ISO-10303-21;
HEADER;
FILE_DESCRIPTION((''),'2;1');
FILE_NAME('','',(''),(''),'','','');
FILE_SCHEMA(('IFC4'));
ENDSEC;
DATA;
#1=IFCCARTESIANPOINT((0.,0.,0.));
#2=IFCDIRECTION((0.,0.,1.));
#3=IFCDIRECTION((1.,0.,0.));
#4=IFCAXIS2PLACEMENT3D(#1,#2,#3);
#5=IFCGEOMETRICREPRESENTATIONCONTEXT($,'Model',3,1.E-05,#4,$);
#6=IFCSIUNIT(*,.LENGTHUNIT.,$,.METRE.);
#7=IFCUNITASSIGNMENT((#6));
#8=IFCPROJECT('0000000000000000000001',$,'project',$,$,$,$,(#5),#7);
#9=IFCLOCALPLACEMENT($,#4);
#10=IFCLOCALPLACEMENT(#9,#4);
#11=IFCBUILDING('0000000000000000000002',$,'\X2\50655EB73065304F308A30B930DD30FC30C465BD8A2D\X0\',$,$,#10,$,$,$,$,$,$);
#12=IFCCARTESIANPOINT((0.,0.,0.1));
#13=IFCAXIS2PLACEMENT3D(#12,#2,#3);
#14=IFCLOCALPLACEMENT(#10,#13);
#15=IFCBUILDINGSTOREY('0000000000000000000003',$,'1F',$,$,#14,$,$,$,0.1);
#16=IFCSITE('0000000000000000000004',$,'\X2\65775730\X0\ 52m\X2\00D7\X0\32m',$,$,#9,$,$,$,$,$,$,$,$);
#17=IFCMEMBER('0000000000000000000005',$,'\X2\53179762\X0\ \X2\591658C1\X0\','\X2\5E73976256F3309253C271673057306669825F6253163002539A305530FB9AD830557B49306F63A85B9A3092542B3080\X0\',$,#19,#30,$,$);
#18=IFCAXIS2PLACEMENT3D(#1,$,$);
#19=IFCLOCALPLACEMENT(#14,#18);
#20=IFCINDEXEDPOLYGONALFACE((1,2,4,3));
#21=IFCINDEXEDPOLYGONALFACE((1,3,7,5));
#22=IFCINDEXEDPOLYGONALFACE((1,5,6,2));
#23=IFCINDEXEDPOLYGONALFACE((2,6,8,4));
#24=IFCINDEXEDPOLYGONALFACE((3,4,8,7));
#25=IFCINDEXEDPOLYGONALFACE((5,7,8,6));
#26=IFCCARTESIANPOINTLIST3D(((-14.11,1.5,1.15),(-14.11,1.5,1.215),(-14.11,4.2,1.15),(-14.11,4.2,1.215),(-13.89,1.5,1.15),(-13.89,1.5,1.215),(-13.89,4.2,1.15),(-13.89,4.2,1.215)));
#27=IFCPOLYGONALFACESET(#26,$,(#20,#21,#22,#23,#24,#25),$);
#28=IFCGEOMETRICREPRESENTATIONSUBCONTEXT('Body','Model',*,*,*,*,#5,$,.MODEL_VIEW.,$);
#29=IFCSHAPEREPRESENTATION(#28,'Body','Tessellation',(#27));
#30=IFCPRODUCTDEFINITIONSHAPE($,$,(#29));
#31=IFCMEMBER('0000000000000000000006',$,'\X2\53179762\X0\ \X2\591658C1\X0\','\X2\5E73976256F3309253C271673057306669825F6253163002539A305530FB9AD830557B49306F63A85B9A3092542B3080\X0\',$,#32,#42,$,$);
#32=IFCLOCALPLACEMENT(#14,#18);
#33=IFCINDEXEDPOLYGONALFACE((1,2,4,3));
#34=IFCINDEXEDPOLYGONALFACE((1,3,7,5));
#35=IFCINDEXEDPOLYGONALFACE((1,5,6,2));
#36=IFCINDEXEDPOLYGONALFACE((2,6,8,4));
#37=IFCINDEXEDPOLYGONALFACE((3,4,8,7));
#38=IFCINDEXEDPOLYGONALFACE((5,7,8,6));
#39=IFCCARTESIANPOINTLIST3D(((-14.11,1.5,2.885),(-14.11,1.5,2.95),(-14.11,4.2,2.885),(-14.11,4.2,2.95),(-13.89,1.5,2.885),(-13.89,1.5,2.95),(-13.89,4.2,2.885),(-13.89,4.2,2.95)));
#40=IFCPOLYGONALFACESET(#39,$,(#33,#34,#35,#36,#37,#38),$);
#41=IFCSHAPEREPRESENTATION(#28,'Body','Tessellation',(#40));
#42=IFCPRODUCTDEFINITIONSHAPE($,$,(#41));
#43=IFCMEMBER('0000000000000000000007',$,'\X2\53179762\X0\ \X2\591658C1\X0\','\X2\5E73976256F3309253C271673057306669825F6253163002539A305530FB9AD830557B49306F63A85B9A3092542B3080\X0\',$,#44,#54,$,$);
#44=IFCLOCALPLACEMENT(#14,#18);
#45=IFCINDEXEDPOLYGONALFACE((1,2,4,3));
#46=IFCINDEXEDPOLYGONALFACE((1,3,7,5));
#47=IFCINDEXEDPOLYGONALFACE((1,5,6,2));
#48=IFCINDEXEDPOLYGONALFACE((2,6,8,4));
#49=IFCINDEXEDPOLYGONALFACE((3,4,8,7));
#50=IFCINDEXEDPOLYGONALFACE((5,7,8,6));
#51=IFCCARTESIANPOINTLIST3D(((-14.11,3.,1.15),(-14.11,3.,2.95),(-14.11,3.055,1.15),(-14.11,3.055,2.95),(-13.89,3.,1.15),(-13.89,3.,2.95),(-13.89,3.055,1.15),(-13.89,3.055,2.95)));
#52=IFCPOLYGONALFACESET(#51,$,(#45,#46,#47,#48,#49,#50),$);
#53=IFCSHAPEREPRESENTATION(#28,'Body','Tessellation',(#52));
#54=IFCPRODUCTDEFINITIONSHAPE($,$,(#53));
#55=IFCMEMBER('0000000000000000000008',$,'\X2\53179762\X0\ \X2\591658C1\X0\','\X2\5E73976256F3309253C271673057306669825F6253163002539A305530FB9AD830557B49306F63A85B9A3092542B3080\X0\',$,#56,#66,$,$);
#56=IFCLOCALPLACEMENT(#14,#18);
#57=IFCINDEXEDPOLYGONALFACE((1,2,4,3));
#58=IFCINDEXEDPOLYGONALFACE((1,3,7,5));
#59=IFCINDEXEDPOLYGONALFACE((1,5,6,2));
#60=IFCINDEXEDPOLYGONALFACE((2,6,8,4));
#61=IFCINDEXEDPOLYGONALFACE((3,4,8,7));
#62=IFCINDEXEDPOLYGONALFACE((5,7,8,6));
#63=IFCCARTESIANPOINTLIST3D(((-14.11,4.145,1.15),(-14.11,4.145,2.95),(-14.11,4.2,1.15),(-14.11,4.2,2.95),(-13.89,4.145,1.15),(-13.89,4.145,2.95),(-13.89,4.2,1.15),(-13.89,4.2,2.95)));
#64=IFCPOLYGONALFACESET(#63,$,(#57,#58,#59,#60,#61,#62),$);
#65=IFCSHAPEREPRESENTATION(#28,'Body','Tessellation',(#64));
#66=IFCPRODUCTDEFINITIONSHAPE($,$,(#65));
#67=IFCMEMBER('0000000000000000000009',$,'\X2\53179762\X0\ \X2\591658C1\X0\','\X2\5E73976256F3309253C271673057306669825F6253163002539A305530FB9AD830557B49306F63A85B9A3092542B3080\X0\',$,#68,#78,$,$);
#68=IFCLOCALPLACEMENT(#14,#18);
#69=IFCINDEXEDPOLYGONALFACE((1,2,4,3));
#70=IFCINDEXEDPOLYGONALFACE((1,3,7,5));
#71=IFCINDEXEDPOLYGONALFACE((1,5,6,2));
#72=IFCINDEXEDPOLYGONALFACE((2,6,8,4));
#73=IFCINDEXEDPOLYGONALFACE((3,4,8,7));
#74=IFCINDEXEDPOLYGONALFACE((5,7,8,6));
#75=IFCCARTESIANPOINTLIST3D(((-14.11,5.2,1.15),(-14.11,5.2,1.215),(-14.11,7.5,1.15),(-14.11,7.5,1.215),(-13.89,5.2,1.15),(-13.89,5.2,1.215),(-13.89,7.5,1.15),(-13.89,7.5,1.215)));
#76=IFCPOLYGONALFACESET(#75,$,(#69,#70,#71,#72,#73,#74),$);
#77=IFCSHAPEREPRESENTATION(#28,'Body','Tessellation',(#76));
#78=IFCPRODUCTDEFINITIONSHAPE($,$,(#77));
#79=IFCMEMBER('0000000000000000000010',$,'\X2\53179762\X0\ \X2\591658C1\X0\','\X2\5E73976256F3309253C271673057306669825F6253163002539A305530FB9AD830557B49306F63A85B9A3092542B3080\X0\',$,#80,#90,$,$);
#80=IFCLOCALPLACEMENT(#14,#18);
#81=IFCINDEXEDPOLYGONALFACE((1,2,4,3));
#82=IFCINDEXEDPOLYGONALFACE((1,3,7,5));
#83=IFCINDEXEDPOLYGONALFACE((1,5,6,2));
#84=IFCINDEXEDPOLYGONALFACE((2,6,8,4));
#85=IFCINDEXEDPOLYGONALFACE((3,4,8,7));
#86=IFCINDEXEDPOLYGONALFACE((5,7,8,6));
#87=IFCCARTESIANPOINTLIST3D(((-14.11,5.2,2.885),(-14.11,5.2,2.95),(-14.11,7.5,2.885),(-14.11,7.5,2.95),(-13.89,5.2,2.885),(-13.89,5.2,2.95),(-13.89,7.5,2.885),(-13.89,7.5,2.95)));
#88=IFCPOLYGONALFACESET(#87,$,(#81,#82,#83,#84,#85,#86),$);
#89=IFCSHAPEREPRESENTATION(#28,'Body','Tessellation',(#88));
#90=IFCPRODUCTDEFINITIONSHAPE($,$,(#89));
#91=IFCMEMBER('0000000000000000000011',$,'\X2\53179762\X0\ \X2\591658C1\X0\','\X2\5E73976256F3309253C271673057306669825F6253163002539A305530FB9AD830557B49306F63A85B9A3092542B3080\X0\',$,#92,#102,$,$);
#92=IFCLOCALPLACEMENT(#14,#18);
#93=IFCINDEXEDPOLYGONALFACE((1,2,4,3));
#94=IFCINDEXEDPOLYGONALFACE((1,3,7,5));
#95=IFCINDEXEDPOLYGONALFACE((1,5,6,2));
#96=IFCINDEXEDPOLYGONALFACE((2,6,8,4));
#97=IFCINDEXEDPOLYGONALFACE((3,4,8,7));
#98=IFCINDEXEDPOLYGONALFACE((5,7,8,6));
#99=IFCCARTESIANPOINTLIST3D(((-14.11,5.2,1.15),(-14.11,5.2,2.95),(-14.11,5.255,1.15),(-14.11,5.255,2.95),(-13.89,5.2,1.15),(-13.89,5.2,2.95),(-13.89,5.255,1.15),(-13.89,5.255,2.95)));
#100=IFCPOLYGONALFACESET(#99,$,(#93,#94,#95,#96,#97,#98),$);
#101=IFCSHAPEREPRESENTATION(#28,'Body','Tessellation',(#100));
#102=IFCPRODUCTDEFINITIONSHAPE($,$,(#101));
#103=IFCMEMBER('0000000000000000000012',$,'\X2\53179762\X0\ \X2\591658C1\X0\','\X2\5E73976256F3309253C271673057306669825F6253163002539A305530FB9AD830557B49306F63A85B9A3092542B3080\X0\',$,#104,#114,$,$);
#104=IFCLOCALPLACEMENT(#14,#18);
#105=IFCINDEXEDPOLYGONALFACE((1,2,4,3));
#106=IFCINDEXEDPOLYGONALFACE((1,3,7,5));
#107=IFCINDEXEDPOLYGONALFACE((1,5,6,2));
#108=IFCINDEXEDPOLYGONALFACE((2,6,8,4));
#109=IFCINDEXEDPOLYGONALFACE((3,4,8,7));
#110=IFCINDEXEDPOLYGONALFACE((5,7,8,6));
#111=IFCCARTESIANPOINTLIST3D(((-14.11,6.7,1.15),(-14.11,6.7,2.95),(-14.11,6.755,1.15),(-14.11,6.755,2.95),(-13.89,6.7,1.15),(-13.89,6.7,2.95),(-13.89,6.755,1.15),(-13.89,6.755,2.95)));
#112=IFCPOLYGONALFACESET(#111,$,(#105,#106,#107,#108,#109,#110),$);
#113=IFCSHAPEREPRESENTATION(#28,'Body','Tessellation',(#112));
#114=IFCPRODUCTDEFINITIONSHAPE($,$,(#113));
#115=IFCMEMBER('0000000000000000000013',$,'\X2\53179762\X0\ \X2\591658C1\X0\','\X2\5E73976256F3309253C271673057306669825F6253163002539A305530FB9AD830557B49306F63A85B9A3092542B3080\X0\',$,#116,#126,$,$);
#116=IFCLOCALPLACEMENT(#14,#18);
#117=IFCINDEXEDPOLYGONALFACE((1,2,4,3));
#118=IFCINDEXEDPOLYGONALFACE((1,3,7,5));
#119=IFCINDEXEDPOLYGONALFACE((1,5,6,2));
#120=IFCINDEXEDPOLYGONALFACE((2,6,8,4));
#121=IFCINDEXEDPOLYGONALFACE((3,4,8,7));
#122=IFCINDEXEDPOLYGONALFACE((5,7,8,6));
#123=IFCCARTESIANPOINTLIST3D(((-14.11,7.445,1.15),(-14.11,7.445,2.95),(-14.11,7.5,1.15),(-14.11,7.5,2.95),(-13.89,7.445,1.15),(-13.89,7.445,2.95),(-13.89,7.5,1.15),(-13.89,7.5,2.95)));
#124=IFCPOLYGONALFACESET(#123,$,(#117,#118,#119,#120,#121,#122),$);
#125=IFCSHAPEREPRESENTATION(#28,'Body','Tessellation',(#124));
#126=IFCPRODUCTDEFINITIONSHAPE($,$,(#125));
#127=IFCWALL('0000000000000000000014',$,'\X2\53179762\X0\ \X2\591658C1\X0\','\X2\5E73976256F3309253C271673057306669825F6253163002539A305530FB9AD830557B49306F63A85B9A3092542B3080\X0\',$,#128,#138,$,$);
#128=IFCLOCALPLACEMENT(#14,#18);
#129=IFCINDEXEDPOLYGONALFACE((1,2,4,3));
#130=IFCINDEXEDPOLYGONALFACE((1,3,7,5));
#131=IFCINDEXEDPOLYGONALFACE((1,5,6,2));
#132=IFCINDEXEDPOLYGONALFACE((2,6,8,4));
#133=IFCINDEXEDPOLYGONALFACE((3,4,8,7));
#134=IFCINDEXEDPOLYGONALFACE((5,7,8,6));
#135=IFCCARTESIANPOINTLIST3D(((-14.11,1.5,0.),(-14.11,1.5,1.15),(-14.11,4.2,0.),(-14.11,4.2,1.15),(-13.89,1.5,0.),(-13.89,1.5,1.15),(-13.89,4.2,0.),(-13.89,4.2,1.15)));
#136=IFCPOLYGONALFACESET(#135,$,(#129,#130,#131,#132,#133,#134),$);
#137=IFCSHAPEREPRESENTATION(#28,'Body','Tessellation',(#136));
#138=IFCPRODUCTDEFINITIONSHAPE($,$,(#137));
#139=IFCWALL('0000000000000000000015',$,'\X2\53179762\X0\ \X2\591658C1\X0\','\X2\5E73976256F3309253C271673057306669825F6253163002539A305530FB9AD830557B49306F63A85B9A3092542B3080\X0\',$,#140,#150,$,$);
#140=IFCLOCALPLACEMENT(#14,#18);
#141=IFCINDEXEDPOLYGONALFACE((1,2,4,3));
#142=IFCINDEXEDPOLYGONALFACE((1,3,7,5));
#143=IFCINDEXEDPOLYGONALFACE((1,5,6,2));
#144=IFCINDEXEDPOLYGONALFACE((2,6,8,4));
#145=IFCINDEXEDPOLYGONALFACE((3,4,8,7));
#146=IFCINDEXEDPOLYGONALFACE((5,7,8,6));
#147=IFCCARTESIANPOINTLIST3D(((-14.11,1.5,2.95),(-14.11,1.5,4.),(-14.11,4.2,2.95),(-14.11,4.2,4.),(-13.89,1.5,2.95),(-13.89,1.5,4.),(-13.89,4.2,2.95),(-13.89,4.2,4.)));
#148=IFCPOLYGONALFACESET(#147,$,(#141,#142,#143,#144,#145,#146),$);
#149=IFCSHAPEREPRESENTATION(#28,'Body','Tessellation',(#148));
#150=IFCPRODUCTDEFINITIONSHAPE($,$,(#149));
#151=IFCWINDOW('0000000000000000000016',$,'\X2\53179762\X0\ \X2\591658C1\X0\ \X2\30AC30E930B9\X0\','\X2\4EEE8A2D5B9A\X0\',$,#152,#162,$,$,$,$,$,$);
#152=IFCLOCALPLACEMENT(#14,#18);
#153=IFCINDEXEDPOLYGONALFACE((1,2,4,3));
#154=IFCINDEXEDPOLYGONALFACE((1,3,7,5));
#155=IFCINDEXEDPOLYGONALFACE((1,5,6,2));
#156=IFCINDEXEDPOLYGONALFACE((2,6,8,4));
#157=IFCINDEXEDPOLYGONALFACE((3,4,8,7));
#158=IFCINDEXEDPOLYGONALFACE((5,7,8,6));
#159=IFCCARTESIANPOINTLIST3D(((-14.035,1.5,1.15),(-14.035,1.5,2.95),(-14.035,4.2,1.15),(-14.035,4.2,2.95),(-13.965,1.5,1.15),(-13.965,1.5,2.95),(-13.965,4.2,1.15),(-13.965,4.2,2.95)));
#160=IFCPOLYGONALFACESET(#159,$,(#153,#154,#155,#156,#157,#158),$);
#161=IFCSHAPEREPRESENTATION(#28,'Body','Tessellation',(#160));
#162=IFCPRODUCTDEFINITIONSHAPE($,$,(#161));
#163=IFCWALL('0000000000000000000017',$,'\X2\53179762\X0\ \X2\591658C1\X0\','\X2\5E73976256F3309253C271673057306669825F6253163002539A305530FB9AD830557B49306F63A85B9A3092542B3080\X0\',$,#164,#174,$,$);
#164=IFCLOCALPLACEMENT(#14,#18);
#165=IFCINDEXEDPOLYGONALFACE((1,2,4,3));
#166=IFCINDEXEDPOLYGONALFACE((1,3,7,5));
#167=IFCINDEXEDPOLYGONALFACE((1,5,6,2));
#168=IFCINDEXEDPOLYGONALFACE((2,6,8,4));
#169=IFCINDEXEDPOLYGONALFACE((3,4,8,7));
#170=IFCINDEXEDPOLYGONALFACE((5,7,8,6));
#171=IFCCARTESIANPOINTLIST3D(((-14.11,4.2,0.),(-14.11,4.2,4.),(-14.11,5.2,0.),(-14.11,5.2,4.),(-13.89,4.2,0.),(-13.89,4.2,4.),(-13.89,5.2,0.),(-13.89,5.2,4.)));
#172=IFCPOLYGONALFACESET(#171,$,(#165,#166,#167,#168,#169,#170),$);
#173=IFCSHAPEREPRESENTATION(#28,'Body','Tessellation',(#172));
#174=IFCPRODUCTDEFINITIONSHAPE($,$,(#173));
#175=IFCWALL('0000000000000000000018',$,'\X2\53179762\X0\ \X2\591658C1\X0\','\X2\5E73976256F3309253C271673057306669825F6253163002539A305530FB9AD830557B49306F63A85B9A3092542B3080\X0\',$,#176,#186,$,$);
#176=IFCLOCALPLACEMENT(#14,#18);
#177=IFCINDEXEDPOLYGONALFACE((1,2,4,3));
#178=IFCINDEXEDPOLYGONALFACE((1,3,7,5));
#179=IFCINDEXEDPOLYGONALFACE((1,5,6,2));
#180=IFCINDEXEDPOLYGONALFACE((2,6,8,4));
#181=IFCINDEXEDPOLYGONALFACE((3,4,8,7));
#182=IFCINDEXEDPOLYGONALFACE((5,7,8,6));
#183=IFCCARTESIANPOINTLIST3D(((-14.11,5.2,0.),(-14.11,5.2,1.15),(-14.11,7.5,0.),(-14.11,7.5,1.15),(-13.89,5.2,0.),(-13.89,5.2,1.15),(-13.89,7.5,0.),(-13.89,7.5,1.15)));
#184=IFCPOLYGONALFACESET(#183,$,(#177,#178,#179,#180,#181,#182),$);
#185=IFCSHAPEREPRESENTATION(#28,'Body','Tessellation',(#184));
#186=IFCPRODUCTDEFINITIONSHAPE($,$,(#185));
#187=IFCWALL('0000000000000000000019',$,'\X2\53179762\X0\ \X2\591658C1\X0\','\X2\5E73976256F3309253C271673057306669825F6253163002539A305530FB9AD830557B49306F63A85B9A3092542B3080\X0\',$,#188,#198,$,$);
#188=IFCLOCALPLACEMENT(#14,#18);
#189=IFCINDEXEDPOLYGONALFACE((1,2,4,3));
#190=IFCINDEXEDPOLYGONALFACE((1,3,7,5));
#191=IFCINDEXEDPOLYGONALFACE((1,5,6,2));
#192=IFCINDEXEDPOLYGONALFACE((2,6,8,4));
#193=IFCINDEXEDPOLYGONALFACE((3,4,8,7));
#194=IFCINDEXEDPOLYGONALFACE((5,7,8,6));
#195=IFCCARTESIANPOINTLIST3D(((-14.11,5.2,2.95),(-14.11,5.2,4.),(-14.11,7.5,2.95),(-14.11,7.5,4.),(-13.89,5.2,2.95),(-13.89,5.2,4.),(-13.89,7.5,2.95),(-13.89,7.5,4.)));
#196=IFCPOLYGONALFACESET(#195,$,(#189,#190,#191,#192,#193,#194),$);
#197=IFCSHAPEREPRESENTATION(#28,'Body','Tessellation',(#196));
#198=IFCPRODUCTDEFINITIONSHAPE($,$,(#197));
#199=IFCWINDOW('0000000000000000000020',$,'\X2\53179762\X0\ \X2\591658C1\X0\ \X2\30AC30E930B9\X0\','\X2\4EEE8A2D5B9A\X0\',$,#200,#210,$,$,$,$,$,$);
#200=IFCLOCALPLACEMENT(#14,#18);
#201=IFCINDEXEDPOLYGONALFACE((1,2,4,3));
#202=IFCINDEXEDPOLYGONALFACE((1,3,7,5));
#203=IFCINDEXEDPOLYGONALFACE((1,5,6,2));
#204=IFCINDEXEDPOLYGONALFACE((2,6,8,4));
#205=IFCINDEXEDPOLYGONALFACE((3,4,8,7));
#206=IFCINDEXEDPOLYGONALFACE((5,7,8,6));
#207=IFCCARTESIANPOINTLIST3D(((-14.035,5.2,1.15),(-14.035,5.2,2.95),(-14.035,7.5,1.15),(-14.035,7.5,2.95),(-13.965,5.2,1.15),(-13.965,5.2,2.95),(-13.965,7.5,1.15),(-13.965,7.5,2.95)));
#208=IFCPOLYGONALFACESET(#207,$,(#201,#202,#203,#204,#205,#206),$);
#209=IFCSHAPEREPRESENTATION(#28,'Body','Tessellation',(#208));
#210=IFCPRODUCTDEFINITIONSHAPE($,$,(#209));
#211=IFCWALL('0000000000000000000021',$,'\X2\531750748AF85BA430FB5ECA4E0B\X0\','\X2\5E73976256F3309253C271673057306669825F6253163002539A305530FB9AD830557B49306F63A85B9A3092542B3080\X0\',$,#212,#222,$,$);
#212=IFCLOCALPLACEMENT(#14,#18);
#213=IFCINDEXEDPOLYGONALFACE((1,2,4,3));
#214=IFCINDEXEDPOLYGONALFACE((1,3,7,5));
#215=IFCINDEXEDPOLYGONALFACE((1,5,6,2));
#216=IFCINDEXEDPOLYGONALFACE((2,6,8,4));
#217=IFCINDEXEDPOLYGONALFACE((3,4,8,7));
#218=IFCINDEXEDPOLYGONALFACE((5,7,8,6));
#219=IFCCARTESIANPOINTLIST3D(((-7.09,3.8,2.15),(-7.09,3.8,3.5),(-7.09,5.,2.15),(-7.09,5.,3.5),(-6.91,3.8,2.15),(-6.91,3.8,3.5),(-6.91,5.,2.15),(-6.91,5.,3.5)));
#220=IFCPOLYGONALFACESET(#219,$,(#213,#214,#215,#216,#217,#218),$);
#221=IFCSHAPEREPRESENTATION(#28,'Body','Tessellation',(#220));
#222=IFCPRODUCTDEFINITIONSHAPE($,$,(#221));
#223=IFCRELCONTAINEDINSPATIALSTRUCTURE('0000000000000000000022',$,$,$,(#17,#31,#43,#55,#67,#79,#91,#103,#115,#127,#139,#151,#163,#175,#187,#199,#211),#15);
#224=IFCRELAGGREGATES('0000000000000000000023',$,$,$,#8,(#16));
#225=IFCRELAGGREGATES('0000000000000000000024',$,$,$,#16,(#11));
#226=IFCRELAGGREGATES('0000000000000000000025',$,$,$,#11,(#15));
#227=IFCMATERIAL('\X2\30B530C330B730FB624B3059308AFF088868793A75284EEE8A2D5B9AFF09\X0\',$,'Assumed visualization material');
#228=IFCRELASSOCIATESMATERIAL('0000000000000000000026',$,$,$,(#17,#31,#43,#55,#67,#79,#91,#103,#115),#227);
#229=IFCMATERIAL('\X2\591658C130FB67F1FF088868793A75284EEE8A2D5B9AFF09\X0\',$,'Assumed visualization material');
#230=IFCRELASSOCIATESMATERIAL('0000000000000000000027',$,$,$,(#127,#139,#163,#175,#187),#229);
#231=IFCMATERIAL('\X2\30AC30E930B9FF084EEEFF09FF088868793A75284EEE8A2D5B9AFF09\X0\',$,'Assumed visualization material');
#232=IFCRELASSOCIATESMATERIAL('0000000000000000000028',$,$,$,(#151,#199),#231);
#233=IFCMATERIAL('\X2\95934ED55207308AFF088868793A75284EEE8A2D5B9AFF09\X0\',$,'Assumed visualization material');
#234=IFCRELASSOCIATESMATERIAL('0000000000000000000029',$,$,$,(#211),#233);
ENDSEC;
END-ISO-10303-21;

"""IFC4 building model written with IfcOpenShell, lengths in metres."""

from ifc_helpers import new_model, si_unit, frame, origin_with_axes, place, context, subcontext, project, spatial, rectangle, extrude, material, element, save


model = new_model("IFC4")

# Units and contexts
model_context = context("Model", 3, precision=1e-05, world=origin_with_axes())
body_context = subcontext(model_context, "Body", "Model", "MODEL_VIEW")
ifc_project = project(units=[si_unit("LENGTHUNIT", "METRE")], contexts=[model_context])

# Site, building, storey
site_placement = place(None, origin_with_axes())
site = spatial("IfcSite", under=ifc_project, at=site_placement, Name="敷地 52m×32m")
building_placement = place(site_placement, origin_with_axes())
building = spatial("IfcBuilding", under=site, at=building_placement, Name="健康づくりスポーツ施設")
storey_placement = place(building_placement, frame((0.0, 0.0, 0.1), z_axis=(0.0, 0.0, 1.0), x_axis=(1.0, 0.0, 0.0)))
storey = spatial("IfcBuildingStorey", under=building, at=storey_placement, Name="1F", Elevation=0.1)

# Members
ifc_material_1 = material(Name="サッシ・手すり（表示用仮設定）", Category="Assumed visualization material")
for number, where, z_axis, x_axis, name in (
    (1, (-14.0, 2.85, 1.15), (0.0, 0.0, 1.0), (1.0, 0.0, 0.0), "北面 外壁"),
    (2, (-14.0, 2.85, 2.885), (0.0, 0.0, 1.0), (1.0, 0.0, 0.0), "北面 外壁"),
):
    element("IfcMember", number, at=place(storey_placement, frame(where, z_axis=z_axis, x_axis=x_axis)), inside=storey, material=ifc_material_1, Name=name, Description="平面図を参照して概形化。厚さ・高さ等は推定を含む", context=body_context, shape_type="SweptSolid", body=[
        extrude(rectangle(XDim=0.22, YDim=2.7), origin_with_axes(), (0.0, 0.0, 1.0), 0.065),
    ])
for number, where, z_axis, x_axis, name in (
    (3, (-14.0, 3.0275, 1.15), (0.0, 0.0, 1.0), (1.0, 0.0, 0.0), "北面 外壁"),
    (4, (-14.0, 4.1725, 1.15), (0.0, 0.0, 1.0), (1.0, 0.0, 0.0), "北面 外壁"),
):
    element("IfcMember", number, at=place(storey_placement, frame(where, z_axis=z_axis, x_axis=x_axis)), inside=storey, material=ifc_material_1, Name=name, Description="平面図を参照して概形化。厚さ・高さ等は推定を含む", context=body_context, shape_type="SweptSolid", body=[
        extrude(rectangle(XDim=0.22, YDim=0.055), origin_with_axes(), (0.0, 0.0, 1.0), 1.8),
    ])
for number, where, z_axis, x_axis, name in (
    (5, (-14.0, 6.35, 1.15), (0.0, 0.0, 1.0), (1.0, 0.0, 0.0), "北面 外壁"),
    (6, (-14.0, 6.35, 2.885), (0.0, 0.0, 1.0), (1.0, 0.0, 0.0), "北面 外壁"),
):
    element("IfcMember", number, at=place(storey_placement, frame(where, z_axis=z_axis, x_axis=x_axis)), inside=storey, material=ifc_material_1, Name=name, Description="平面図を参照して概形化。厚さ・高さ等は推定を含む", context=body_context, shape_type="SweptSolid", body=[
        extrude(rectangle(XDim=0.22, YDim=2.3), origin_with_axes(), (0.0, 0.0, 1.0), 0.065),
    ])
for number, where, z_axis, x_axis, name in (
    (7, (-14.0, 5.2275, 1.15), (0.0, 0.0, 1.0), (1.0, 0.0, 0.0), "北面 外壁"),
    (8, (-14.0, 6.7275, 1.15), (0.0, 0.0, 1.0), (1.0, 0.0, 0.0), "北面 外壁"),
    (9, (-14.0, 7.4725, 1.15), (0.0, 0.0, 1.0), (1.0, 0.0, 0.0), "北面 外壁"),
):
    element("IfcMember", number, at=place(storey_placement, frame(where, z_axis=z_axis, x_axis=x_axis)), inside=storey, material=ifc_material_1, Name=name, Description="平面図を参照して概形化。厚さ・高さ等は推定を含む", context=body_context, shape_type="SweptSolid", body=[
        extrude(rectangle(XDim=0.22, YDim=0.055), origin_with_axes(), (0.0, 0.0, 1.0), 1.8),
    ])

# Walls
ifc_material_2 = material(Name="外壁・柱（表示用仮設定）", Category="Assumed visualization material")
wall_1_placement = place(storey_placement, frame((-14.0, 2.85, 0.0), z_axis=(0.0, 0.0, 1.0), x_axis=(1.0, 0.0, 0.0)))
element("IfcWall", 10, at=wall_1_placement, inside=storey, material=ifc_material_2, Name="北面 外壁", Description="平面図を参照して概形化。厚さ・高さ等は推定を含む", context=body_context, shape_type="SweptSolid", body=[
    extrude(rectangle(XDim=0.22, YDim=2.7), origin_with_axes(), (0.0, 0.0, 1.0), 1.15),
])
wall_2_placement = place(storey_placement, frame((-14.0, 2.85, 2.95), z_axis=(0.0, 0.0, 1.0), x_axis=(1.0, 0.0, 0.0)))
element("IfcWall", 11, at=wall_2_placement, inside=storey, material=ifc_material_2, Name="北面 外壁", Description="平面図を参照して概形化。厚さ・高さ等は推定を含む", context=body_context, shape_type="SweptSolid", body=[
    extrude(rectangle(XDim=0.22, YDim=2.7), origin_with_axes(), (0.0, 0.0, 1.0), 1.05),
])

# Window
ifc_material_3 = material(Name="ガラス（仮）（表示用仮設定）", Category="Assumed visualization material")
window_1_placement = place(storey_placement, frame((-14.0, 2.85, 1.15), z_axis=(0.0, 0.0, 1.0), x_axis=(1.0, 0.0, 0.0)))
element("IfcWindow", 12, at=window_1_placement, inside=storey, material=ifc_material_3, Name="北面 外壁 ガラス", Description="仮設定", context=body_context, shape_type="SweptSolid", body=[
    extrude(rectangle(XDim=0.07, YDim=2.7), origin_with_axes(), (0.0, 0.0, 1.0), 1.8),
])

# Walls
wall_3_placement = place(storey_placement, frame((-14.0, 4.7, 0.0), z_axis=(0.0, 0.0, 1.0), x_axis=(1.0, 0.0, 0.0)))
element("IfcWall", 13, at=wall_3_placement, inside=storey, material=ifc_material_2, Name="北面 外壁", Description="平面図を参照して概形化。厚さ・高さ等は推定を含む", context=body_context, shape_type="SweptSolid", body=[
    extrude(rectangle(XDim=0.22, YDim=1.0), origin_with_axes(), (0.0, 0.0, 1.0), 4.0),
])
wall_4_placement = place(storey_placement, frame((-14.0, 6.35, 0.0), z_axis=(0.0, 0.0, 1.0), x_axis=(1.0, 0.0, 0.0)))
element("IfcWall", 14, at=wall_4_placement, inside=storey, material=ifc_material_2, Name="北面 外壁", Description="平面図を参照して概形化。厚さ・高さ等は推定を含む", context=body_context, shape_type="SweptSolid", body=[
    extrude(rectangle(XDim=0.22, YDim=2.3), origin_with_axes(), (0.0, 0.0, 1.0), 1.15),
])
wall_5_placement = place(storey_placement, frame((-14.0, 6.35, 2.95), z_axis=(0.0, 0.0, 1.0), x_axis=(1.0, 0.0, 0.0)))
element("IfcWall", 15, at=wall_5_placement, inside=storey, material=ifc_material_2, Name="北面 外壁", Description="平面図を参照して概形化。厚さ・高さ等は推定を含む", context=body_context, shape_type="SweptSolid", body=[
    extrude(rectangle(XDim=0.22, YDim=2.3), origin_with_axes(), (0.0, 0.0, 1.0), 1.05),
])

# Window
window_2_placement = place(storey_placement, frame((-14.0, 6.35, 1.15), z_axis=(0.0, 0.0, 1.0), x_axis=(1.0, 0.0, 0.0)))
element("IfcWindow", 16, at=window_2_placement, inside=storey, material=ifc_material_3, Name="北面 外壁 ガラス", Description="仮設定", context=body_context, shape_type="SweptSolid", body=[
    extrude(rectangle(XDim=0.07, YDim=2.3), origin_with_axes(), (0.0, 0.0, 1.0), 1.8),
])

# Wall
ifc_material_4 = material(Name="間仕切り（表示用仮設定）", Category="Assumed visualization material")
wall_6_placement = place(storey_placement, frame((-7.0, 4.4, 2.15), z_axis=(0.0, 0.0, 1.0), x_axis=(1.0, 0.0, 0.0)))
element("IfcWall", 17, at=wall_6_placement, inside=storey, material=ifc_material_4, Name="北側諸室・廊下", Description="平面図を参照して概形化。厚さ・高さ等は推定を含む", context=body_context, shape_type="SweptSolid", body=[
    extrude(rectangle(XDim=0.18, YDim=1.2), origin_with_axes(), (0.0, 0.0, 1.0), 1.35),
])

save(model, "model.ifc")
